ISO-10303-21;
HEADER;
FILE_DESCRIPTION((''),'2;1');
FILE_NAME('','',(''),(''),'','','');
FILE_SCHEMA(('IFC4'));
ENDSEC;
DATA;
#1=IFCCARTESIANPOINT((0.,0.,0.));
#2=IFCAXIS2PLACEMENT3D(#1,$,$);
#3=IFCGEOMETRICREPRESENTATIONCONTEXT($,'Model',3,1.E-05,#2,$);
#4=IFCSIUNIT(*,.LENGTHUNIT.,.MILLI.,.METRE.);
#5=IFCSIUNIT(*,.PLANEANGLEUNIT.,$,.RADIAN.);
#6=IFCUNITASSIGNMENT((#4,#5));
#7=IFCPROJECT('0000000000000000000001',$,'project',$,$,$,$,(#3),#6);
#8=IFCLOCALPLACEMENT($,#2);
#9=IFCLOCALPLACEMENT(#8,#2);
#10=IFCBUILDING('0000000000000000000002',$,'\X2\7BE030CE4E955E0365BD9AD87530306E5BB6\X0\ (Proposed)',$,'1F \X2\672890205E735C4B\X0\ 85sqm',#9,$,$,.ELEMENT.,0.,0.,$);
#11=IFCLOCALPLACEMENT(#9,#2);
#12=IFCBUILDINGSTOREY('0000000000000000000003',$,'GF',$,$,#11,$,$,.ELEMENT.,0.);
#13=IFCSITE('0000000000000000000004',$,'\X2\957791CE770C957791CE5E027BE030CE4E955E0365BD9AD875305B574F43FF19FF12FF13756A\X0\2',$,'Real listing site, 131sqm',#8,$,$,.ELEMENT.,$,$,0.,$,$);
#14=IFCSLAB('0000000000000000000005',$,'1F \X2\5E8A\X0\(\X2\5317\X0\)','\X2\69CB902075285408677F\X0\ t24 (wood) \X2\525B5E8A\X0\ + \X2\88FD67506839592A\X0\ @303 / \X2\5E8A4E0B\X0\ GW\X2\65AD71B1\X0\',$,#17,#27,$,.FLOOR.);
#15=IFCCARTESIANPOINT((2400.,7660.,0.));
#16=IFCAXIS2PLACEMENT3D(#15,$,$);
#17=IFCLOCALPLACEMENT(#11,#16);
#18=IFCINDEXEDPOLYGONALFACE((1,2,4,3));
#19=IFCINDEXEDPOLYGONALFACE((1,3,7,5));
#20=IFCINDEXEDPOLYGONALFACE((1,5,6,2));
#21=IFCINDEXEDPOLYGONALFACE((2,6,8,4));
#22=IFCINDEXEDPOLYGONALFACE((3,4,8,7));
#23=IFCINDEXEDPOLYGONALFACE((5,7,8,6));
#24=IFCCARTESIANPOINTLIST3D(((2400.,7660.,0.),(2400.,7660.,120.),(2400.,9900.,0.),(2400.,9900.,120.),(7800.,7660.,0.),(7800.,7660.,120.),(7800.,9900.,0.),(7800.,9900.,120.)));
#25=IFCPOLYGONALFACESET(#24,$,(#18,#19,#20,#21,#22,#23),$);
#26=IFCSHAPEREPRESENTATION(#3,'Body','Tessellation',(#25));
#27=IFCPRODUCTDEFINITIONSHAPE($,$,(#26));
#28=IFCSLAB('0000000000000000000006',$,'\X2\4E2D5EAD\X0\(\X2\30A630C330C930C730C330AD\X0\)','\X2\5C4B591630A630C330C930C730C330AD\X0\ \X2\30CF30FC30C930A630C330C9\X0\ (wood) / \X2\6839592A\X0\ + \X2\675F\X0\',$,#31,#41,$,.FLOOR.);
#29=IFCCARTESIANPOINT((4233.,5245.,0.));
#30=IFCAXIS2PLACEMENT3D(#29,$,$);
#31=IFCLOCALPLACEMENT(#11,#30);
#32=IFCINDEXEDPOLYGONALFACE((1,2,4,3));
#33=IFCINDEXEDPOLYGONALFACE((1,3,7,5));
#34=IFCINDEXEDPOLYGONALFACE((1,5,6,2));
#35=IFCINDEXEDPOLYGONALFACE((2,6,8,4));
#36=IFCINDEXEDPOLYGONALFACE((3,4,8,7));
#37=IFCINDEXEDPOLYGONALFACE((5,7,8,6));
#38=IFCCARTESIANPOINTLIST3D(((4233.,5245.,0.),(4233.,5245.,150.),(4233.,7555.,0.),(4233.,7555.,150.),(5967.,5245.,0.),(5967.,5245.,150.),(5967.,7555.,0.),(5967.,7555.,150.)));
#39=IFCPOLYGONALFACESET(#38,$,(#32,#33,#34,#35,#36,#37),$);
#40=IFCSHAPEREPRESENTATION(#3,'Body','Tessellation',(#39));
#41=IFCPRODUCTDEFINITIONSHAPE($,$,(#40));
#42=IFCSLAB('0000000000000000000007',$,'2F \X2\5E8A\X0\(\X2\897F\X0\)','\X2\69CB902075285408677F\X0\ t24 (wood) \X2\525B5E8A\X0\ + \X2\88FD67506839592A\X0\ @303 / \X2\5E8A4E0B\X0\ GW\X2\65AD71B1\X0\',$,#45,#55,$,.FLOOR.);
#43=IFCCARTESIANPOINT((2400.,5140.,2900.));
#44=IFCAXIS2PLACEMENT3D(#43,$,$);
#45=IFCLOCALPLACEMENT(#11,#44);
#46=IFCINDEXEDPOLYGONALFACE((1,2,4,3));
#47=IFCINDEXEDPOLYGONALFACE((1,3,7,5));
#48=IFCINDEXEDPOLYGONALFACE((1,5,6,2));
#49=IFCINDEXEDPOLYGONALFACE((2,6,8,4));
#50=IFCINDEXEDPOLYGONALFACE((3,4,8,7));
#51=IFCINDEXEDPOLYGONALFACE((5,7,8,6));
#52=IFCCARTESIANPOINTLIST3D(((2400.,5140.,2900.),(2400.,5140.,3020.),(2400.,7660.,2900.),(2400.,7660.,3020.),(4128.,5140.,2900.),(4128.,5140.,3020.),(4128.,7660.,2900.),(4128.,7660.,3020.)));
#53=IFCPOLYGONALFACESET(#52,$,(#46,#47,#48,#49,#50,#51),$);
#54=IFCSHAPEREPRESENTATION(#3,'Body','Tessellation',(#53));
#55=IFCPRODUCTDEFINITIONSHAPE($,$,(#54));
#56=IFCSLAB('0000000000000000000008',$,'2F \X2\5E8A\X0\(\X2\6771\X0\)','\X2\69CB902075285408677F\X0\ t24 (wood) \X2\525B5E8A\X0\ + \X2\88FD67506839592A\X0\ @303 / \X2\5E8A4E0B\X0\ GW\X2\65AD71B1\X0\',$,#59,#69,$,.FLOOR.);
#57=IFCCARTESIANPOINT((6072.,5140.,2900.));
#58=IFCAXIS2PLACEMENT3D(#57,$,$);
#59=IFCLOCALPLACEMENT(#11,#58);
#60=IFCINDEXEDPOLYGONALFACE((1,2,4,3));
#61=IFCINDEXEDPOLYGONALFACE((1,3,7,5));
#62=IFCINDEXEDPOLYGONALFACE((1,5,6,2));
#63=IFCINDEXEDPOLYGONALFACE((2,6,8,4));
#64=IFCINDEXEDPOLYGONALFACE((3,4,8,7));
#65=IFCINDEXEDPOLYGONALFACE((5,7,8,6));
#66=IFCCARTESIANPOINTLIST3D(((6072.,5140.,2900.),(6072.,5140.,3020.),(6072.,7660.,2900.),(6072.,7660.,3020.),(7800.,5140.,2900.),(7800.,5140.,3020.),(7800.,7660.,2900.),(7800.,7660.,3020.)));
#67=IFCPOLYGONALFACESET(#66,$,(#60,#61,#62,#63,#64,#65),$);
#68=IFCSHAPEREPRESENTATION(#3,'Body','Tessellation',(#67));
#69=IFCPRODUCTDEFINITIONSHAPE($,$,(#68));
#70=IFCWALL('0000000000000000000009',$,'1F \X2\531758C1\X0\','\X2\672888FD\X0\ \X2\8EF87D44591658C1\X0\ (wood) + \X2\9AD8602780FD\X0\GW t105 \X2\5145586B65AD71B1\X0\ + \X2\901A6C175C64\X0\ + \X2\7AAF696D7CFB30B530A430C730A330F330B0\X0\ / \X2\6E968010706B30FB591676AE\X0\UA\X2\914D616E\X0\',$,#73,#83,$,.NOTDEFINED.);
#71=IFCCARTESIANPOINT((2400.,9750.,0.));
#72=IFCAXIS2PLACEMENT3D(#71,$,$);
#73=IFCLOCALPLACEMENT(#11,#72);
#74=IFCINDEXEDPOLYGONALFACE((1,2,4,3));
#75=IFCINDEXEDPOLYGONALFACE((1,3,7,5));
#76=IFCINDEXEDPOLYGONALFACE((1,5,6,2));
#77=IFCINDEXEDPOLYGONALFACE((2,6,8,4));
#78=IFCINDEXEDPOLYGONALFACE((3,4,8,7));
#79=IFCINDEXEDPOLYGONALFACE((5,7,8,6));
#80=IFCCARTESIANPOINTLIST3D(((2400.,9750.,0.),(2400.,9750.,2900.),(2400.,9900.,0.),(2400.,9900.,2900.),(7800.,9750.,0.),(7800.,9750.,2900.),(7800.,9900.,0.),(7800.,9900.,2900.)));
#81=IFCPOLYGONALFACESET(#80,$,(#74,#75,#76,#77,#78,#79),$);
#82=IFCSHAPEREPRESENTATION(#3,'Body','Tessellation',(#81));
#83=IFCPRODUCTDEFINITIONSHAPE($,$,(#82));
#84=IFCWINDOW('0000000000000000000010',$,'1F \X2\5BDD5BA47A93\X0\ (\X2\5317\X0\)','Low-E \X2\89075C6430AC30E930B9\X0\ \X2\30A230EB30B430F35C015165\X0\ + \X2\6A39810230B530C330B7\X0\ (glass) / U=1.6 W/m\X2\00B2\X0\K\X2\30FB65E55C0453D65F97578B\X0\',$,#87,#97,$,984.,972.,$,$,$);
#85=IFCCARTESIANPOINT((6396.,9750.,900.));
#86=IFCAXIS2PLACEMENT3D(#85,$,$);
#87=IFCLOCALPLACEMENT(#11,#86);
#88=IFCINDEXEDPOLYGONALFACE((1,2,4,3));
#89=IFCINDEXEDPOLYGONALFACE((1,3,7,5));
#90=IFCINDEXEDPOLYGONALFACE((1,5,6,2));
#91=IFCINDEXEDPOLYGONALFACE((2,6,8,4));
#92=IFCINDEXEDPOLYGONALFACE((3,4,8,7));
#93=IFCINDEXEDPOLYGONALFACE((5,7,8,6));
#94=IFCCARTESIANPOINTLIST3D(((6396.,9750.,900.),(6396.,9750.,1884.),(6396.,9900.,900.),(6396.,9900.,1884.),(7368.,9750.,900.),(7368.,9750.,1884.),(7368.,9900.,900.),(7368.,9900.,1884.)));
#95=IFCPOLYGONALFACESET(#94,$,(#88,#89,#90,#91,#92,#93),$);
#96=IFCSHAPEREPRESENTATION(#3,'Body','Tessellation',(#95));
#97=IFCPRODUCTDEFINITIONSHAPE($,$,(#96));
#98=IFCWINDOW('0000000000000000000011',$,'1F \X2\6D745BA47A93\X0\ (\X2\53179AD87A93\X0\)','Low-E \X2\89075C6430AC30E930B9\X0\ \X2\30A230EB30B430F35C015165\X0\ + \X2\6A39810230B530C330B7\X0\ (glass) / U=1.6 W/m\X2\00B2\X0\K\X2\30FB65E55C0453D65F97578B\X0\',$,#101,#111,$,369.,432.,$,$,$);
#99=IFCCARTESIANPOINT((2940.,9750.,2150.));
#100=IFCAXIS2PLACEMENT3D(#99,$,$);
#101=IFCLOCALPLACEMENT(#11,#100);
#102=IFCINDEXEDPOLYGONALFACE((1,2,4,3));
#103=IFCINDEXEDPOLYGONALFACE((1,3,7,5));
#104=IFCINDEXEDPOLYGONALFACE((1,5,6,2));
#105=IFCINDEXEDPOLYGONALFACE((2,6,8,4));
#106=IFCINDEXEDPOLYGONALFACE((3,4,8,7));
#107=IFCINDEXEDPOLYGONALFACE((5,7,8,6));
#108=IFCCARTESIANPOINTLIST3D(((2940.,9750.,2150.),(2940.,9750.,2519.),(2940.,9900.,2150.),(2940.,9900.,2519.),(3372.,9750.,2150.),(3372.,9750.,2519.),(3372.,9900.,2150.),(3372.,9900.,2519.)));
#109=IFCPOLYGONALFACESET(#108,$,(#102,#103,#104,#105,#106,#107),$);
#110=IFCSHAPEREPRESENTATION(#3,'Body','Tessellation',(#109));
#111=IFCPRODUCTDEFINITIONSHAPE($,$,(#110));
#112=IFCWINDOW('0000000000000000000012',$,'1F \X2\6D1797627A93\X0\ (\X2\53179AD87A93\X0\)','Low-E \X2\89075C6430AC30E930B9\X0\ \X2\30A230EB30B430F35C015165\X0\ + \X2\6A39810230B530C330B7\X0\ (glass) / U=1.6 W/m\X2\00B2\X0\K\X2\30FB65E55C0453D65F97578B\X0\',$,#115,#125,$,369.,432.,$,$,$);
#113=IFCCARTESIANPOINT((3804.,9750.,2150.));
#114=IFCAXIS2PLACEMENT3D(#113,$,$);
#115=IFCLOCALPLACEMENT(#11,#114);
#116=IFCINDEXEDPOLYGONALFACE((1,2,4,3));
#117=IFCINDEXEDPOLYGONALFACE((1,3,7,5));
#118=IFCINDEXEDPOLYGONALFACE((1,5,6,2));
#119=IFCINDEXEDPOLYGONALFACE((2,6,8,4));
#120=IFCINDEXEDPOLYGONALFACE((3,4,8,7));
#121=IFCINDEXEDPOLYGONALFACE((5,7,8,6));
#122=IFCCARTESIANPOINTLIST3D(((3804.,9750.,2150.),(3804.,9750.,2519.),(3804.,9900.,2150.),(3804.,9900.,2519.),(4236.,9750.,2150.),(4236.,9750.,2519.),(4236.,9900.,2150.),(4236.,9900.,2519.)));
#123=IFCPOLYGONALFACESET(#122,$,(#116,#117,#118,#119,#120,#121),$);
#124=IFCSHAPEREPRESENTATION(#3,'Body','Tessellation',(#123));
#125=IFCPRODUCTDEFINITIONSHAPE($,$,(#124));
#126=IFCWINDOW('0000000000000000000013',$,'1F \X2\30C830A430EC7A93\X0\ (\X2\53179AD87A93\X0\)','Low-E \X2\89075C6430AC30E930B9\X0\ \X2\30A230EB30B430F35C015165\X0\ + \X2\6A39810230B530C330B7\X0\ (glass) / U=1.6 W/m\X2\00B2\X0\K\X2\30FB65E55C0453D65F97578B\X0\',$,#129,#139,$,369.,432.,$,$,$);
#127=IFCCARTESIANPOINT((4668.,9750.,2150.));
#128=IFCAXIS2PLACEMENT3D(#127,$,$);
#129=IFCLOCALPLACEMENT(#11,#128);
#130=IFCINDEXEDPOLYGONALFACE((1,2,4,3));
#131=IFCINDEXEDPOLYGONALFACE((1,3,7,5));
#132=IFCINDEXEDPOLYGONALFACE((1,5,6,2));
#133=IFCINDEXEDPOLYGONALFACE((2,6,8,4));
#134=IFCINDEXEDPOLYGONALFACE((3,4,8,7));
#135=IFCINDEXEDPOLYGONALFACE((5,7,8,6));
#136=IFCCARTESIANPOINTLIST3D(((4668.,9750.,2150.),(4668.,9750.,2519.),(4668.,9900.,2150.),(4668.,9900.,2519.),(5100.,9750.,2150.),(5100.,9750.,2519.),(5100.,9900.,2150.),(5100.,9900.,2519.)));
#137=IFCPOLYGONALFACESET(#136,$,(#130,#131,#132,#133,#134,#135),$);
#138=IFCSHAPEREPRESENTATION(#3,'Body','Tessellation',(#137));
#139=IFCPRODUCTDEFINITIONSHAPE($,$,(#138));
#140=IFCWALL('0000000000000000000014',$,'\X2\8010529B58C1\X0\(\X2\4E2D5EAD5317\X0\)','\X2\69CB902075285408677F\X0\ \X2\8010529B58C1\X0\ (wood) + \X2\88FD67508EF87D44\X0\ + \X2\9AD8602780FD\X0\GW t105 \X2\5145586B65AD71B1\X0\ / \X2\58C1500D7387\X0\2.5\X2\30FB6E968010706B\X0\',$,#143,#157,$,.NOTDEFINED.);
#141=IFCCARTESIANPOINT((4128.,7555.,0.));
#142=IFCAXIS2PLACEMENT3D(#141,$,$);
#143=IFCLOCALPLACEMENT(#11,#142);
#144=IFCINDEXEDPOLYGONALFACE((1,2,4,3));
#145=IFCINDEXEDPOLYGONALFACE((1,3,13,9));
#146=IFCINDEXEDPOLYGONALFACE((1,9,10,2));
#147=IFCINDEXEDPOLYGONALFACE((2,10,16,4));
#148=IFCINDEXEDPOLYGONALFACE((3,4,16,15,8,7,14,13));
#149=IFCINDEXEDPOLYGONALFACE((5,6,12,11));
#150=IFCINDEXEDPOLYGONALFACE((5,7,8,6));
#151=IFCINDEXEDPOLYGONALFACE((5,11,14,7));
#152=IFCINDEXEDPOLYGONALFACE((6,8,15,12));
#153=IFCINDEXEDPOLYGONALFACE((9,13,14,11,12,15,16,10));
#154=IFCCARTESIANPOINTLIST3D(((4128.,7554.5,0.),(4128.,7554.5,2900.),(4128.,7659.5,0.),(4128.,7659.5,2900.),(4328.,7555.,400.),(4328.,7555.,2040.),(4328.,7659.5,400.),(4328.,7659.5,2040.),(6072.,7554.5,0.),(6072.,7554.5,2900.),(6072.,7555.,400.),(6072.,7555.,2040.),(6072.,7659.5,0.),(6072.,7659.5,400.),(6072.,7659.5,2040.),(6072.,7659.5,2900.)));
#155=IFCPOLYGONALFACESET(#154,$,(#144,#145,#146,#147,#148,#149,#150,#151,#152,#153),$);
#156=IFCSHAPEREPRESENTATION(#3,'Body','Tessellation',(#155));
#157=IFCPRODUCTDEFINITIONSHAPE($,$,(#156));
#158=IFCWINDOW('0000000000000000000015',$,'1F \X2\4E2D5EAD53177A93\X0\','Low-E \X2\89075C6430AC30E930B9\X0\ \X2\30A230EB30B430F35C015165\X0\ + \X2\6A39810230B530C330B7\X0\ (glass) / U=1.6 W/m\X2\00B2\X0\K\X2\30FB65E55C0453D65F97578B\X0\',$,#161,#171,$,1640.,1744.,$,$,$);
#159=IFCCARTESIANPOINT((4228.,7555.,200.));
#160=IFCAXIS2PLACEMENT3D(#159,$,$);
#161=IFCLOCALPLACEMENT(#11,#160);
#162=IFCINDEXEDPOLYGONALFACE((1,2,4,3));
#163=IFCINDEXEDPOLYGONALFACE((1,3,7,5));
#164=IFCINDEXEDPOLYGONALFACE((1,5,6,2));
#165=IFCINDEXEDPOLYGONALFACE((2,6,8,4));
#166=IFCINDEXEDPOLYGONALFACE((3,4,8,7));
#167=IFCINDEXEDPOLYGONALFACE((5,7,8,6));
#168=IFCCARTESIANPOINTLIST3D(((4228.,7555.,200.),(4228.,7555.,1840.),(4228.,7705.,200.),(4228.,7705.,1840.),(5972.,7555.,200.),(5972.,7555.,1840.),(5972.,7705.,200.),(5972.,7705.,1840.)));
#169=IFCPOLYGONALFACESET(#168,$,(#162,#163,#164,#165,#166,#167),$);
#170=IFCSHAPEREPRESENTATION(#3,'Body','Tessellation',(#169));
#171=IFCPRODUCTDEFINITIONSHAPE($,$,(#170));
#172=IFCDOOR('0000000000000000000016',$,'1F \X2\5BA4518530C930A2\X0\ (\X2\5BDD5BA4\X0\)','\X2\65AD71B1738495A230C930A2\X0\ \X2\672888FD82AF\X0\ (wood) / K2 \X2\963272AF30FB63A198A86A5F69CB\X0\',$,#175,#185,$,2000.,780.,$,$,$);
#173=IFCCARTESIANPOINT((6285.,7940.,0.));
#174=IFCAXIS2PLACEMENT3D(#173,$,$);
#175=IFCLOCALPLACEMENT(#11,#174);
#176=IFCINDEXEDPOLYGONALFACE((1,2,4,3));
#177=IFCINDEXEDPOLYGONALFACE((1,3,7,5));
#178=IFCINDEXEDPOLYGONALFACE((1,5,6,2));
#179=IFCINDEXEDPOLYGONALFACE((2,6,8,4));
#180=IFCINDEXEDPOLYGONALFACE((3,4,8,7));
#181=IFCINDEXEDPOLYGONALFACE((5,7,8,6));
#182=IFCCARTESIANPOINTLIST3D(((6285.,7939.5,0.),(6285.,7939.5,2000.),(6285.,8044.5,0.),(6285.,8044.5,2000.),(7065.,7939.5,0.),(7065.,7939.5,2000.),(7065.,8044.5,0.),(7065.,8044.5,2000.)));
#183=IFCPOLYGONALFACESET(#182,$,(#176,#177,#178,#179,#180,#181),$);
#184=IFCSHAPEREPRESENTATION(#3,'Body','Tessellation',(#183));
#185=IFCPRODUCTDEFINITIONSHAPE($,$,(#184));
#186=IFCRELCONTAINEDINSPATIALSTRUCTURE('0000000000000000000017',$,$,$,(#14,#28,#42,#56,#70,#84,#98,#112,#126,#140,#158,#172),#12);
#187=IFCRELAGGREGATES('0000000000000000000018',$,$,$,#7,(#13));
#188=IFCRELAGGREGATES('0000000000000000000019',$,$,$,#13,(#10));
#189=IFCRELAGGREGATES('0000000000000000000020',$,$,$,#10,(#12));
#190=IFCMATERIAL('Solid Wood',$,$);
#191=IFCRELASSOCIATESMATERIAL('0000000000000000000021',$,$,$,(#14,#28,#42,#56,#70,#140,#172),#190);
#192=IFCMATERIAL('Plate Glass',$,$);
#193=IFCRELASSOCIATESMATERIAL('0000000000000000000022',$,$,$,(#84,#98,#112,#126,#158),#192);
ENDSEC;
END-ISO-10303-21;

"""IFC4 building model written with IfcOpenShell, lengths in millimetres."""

from ifc_helpers import new_model, si_unit, frame, frame_2d, origin, place, context, project, spatial, rectangle, extrude, material, element, fill, save


model = new_model("IFC4")

# Units and contexts
model_context = context("Model", 3, precision=1e-05, world=origin())
ifc_project = project(units=[si_unit("LENGTHUNIT", "METRE", prefix="MILLI"), si_unit("PLANEANGLEUNIT", "RADIAN")], contexts=[model_context])

# Site, building, storey
site_placement = place(None, origin())
site = spatial("IfcSite", under=ifc_project, at=site_placement, Name="長野県長野市篠ノ井布施高田字佃９２３番2", ObjectType="Real listing site, 131sqm", CompositionType="ELEMENT", RefElevation=0.0)
building_placement = place(site_placement, origin())
building = spatial("IfcBuilding", under=site, at=building_placement, Name="篠ノ井布施高田の家 (Proposed)", ObjectType="1F 木造平屋 85sqm", CompositionType="ELEMENT", ElevationOfRefHeight=0.0, ElevationOfTerrain=0.0)
storey_placement = place(building_placement, origin())
storey = spatial("IfcBuildingStorey", under=building, at=storey_placement, Name="GF", CompositionType="ELEMENT", Elevation=0.0)

# Slabs
ifc_material_1 = material(Name="Solid Wood")
slab_1_placement = place(storey_placement, frame((2400.0, 7660.0, 0.0)))
element("IfcSlab", 1, at=slab_1_placement, inside=storey, material=ifc_material_1, Name="1F 床(北)", Description="構造用合板 t24 (wood) 剛床 + 製材根太 @303 / 床下 GW断熱", PredefinedType="FLOOR", context=model_context, shape_type="SweptSolid", body=[
    extrude(rectangle(XDim=5400.0, YDim=2240.0, at=frame_2d((2700.0, 1120.0))), frame((2400.0, 7660.0, 0.0)), (0.0, 0.0, 1.0), 120.0),
])
slab_2_placement = place(storey_placement, frame((4233.0, 5245.0, 0.0)))
element("IfcSlab", 2, at=slab_2_placement, inside=storey, material=ifc_material_1, Name="中庭(ウッドデッキ)", Description="屋外ウッドデッキ ハードウッド (wood) / 根太 + 束", PredefinedType="FLOOR", context=model_context, shape_type="SweptSolid", body=[
    extrude(rectangle(XDim=1734.0, YDim=2310.0, at=frame_2d((867.0, 1155.0))), frame((4233.0, 5245.0, 0.0)), (0.0, 0.0, 1.0), 150.0),
])
slab_3_placement = place(storey_placement, frame((2400.0, 5140.0, 2900.0)))
element("IfcSlab", 3, at=slab_3_placement, inside=storey, material=ifc_material_1, Name="2F 床(西)", Description="構造用合板 t24 (wood) 剛床 + 製材根太 @303 / 床下 GW断熱", PredefinedType="FLOOR", context=model_context, shape_type="SweptSolid", body=[
    extrude(rectangle(XDim=1728.0, YDim=2520.0, at=frame_2d((864.0, 1260.0))), frame((2400.0, 5140.0, 2900.0)), (0.0, 0.0, 1.0), 120.0),
])
slab_4_placement = place(storey_placement, frame((6072.0, 5140.0, 2900.0)))
element("IfcSlab", 4, at=slab_4_placement, inside=storey, material=ifc_material_1, Name="2F 床(東)", Description="構造用合板 t24 (wood) 剛床 + 製材根太 @303 / 床下 GW断熱", PredefinedType="FLOOR", context=model_context, shape_type="SweptSolid", body=[
    extrude(rectangle(XDim=1728.0, YDim=2520.0, at=frame_2d((864.0, 1260.0))), frame((6072.0, 5140.0, 2900.0)), (0.0, 0.0, 1.0), 120.0),
])

# Wall, openings, windows
wall_1_placement = place(storey_placement, frame((2400.0, 9750.0, 0.0)))
wall_1 = element("IfcWall", 5, at=wall_1_placement, inside=storey, material=ifc_material_1, Name="1F 北壁", Description="木製 軸組外壁 (wood) + 高性能GW t105 充填断熱 + 通気層 + 窯業系サイディング / 準耐火・外皮UA配慮", PredefinedType="NOTDEFINED", context=model_context, shape_type="SweptSolid", body=[
    extrude(rectangle(XDim=5400.0, YDim=150.0, at=frame_2d((2700.0, 75.0))), frame((2400.0, 9750.0, 0.0)), (0.0, 0.0, 1.0), 2900.0),
])
opening_1_placement = place(storey_placement, frame((6396.0, 9750.0, 900.0)))
opening_1 = element("IfcOpeningElement", 6, at=opening_1_placement, cuts=wall_1, PredefinedType="NOTDEFINED", context=model_context, shape_type="SweptSolid", body=[
    extrude(rectangle(XDim=972.0, YDim=150.0, at=frame_2d((486.0, 75.0))), frame((6396.0, 9750.0, 900.0)), (0.0, 0.0, 1.0), 984.0),
])
opening_2_placement = place(storey_placement, frame((2940.0, 9750.0, 2150.0)))
opening_2 = element("IfcOpeningElement", 7, at=opening_2_placement, cuts=wall_1, PredefinedType="NOTDEFINED", context=model_context, shape_type="SweptSolid", body=[
    extrude(rectangle(XDim=432.0, YDim=150.0, at=frame_2d((216.0, 75.0))), frame((2940.0, 9750.0, 2150.0)), (0.0, 0.0, 1.0), 369.0),
])
opening_3_placement = place(storey_placement, frame((3804.0, 9750.0, 2150.0)))
opening_3 = element("IfcOpeningElement", 8, at=opening_3_placement, cuts=wall_1, PredefinedType="NOTDEFINED", context=model_context, shape_type="SweptSolid", body=[
    extrude(rectangle(XDim=432.0, YDim=150.0, at=frame_2d((216.0, 75.0))), frame((3804.0, 9750.0, 2150.0)), (0.0, 0.0, 1.0), 369.0),
])
opening_4_placement = place(storey_placement, frame((4668.0, 9750.0, 2150.0)))
opening_4 = element("IfcOpeningElement", 9, at=opening_4_placement, cuts=wall_1, PredefinedType="NOTDEFINED", context=model_context, shape_type="SweptSolid", body=[
    extrude(rectangle(XDim=432.0, YDim=150.0, at=frame_2d((216.0, 75.0))), frame((4668.0, 9750.0, 2150.0)), (0.0, 0.0, 1.0), 369.0),
])
ifc_material_2 = material(Name="Plate Glass")
window_1_placement = place(storey_placement, frame((6396.0, 9750.0, 900.0)))
window_1 = element("IfcWindow", 10, at=window_1_placement, inside=storey, material=ifc_material_2, Name="1F 寝室窓 (北)", Description="Low-E 複層ガラス アルゴン封入 + 樹脂サッシ (glass) / U=1.6 W/m²K・日射取得型", OverallHeight=984.0, OverallWidth=972.0, context=model_context, shape_type="SweptSolid", body=[
    extrude(rectangle(XDim=972.0, YDim=150.0, at=frame_2d((486.0, 75.0))), frame((6396.0, 9750.0, 900.0)), (0.0, 0.0, 1.0), 984.0),
])
fill(opening_1, window_1)
window_2_placement = place(storey_placement, frame((2940.0, 9750.0, 2150.0)))
window_2 = element("IfcWindow", 11, at=window_2_placement, inside=storey, material=ifc_material_2, Name="1F 浴室窓 (北高窓)", Description="Low-E 複層ガラス アルゴン封入 + 樹脂サッシ (glass) / U=1.6 W/m²K・日射取得型", OverallHeight=369.0, OverallWidth=432.0, context=model_context, shape_type="SweptSolid", body=[
    extrude(rectangle(XDim=432.0, YDim=150.0, at=frame_2d((216.0, 75.0))), frame((2940.0, 9750.0, 2150.0)), (0.0, 0.0, 1.0), 369.0),
])
fill(opening_2, window_2)
window_3_placement = place(storey_placement, frame((3804.0, 9750.0, 2150.0)))
window_3 = element("IfcWindow", 12, at=window_3_placement, inside=storey, material=ifc_material_2, Name="1F 洗面窓 (北高窓)", Description="Low-E 複層ガラス アルゴン封入 + 樹脂サッシ (glass) / U=1.6 W/m²K・日射取得型", OverallHeight=369.0, OverallWidth=432.0, context=model_context, shape_type="SweptSolid", body=[
    extrude(rectangle(XDim=432.0, YDim=150.0, at=frame_2d((216.0, 75.0))), frame((3804.0, 9750.0, 2150.0)), (0.0, 0.0, 1.0), 369.0),
])
fill(opening_3, window_3)
window_4_placement = place(storey_placement, frame((4668.0, 9750.0, 2150.0)))
window_4 = element("IfcWindow", 13, at=window_4_placement, inside=storey, material=ifc_material_2, Name="1F トイレ窓 (北高窓)", Description="Low-E 複層ガラス アルゴン封入 + 樹脂サッシ (glass) / U=1.6 W/m²K・日射取得型", OverallHeight=369.0, OverallWidth=432.0, context=model_context, shape_type="SweptSolid", body=[
    extrude(rectangle(XDim=432.0, YDim=150.0, at=frame_2d((216.0, 75.0))), frame((4668.0, 9750.0, 2150.0)), (0.0, 0.0, 1.0), 369.0),
])
fill(opening_4, window_4)

# Wall, opening, window
wall_2_placement = place(storey_placement, frame((4128.0, 7555.0, 0.0)))
wall_2 = element("IfcWall", 14, at=wall_2_placement, inside=storey, material=ifc_material_1, Name="耐力壁(中庭北)", Description="構造用合板 耐力壁 (wood) + 製材軸組 + 高性能GW t105 充填断熱 / 壁倍率2.5・準耐火", PredefinedType="NOTDEFINED", context=model_context, shape_type="SweptSolid", body=[
    extrude(rectangle(XDim=1944.0, YDim=105.0, at=frame_2d((972.0, 52.0))), frame((4128.0, 7555.0, 0.0)), (0.0, 0.0, 1.0), 2900.0),
])
opening_5_placement = place(storey_placement, frame((4228.0, 7555.0, 200.0)))
opening_5 = element("IfcOpeningElement", 15, at=opening_5_placement, cuts=wall_2, PredefinedType="NOTDEFINED", context=model_context, shape_type="SweptSolid", body=[
    extrude(rectangle(XDim=1744.0, YDim=150.0, at=frame_2d((872.0, 75.0))), frame((4228.0, 7555.0, 200.0)), (0.0, 0.0, 1.0), 1640.0),
])
window_5_placement = place(storey_placement, frame((4228.0, 7555.0, 200.0)))
window_5 = element("IfcWindow", 16, at=window_5_placement, inside=storey, material=ifc_material_2, Name="1F 中庭北窓", Description="Low-E 複層ガラス アルゴン封入 + 樹脂サッシ (glass) / U=1.6 W/m²K・日射取得型", OverallHeight=1640.0, OverallWidth=1744.0, context=model_context, shape_type="SweptSolid", body=[
    extrude(rectangle(XDim=1744.0, YDim=150.0, at=frame_2d((872.0, 75.0))), frame((4228.0, 7555.0, 200.0)), (0.0, 0.0, 1.0), 1640.0),
])
fill(opening_5, window_5)

# Door
door_1_placement = place(storey_placement, frame((6285.0, 7940.0, 0.0)))
element("IfcDoor", 17, at=door_1_placement, inside=storey, material=ifc_material_1, Name="1F 室内ドア (寝室)", Description="断熱玄関ドア 木製芯 (wood) / K2 防犯・採風機構", OverallHeight=2000.0, OverallWidth=780.0, context=model_context, shape_type="SweptSolid", body=[
    extrude(rectangle(XDim=780.0, YDim=105.0, at=frame_2d((390.0, 52.0))), frame((6285.0, 7940.0, 0.0)), (0.0, 0.0, 1.0), 2000.0),
])

save(model, "model.ifc")
